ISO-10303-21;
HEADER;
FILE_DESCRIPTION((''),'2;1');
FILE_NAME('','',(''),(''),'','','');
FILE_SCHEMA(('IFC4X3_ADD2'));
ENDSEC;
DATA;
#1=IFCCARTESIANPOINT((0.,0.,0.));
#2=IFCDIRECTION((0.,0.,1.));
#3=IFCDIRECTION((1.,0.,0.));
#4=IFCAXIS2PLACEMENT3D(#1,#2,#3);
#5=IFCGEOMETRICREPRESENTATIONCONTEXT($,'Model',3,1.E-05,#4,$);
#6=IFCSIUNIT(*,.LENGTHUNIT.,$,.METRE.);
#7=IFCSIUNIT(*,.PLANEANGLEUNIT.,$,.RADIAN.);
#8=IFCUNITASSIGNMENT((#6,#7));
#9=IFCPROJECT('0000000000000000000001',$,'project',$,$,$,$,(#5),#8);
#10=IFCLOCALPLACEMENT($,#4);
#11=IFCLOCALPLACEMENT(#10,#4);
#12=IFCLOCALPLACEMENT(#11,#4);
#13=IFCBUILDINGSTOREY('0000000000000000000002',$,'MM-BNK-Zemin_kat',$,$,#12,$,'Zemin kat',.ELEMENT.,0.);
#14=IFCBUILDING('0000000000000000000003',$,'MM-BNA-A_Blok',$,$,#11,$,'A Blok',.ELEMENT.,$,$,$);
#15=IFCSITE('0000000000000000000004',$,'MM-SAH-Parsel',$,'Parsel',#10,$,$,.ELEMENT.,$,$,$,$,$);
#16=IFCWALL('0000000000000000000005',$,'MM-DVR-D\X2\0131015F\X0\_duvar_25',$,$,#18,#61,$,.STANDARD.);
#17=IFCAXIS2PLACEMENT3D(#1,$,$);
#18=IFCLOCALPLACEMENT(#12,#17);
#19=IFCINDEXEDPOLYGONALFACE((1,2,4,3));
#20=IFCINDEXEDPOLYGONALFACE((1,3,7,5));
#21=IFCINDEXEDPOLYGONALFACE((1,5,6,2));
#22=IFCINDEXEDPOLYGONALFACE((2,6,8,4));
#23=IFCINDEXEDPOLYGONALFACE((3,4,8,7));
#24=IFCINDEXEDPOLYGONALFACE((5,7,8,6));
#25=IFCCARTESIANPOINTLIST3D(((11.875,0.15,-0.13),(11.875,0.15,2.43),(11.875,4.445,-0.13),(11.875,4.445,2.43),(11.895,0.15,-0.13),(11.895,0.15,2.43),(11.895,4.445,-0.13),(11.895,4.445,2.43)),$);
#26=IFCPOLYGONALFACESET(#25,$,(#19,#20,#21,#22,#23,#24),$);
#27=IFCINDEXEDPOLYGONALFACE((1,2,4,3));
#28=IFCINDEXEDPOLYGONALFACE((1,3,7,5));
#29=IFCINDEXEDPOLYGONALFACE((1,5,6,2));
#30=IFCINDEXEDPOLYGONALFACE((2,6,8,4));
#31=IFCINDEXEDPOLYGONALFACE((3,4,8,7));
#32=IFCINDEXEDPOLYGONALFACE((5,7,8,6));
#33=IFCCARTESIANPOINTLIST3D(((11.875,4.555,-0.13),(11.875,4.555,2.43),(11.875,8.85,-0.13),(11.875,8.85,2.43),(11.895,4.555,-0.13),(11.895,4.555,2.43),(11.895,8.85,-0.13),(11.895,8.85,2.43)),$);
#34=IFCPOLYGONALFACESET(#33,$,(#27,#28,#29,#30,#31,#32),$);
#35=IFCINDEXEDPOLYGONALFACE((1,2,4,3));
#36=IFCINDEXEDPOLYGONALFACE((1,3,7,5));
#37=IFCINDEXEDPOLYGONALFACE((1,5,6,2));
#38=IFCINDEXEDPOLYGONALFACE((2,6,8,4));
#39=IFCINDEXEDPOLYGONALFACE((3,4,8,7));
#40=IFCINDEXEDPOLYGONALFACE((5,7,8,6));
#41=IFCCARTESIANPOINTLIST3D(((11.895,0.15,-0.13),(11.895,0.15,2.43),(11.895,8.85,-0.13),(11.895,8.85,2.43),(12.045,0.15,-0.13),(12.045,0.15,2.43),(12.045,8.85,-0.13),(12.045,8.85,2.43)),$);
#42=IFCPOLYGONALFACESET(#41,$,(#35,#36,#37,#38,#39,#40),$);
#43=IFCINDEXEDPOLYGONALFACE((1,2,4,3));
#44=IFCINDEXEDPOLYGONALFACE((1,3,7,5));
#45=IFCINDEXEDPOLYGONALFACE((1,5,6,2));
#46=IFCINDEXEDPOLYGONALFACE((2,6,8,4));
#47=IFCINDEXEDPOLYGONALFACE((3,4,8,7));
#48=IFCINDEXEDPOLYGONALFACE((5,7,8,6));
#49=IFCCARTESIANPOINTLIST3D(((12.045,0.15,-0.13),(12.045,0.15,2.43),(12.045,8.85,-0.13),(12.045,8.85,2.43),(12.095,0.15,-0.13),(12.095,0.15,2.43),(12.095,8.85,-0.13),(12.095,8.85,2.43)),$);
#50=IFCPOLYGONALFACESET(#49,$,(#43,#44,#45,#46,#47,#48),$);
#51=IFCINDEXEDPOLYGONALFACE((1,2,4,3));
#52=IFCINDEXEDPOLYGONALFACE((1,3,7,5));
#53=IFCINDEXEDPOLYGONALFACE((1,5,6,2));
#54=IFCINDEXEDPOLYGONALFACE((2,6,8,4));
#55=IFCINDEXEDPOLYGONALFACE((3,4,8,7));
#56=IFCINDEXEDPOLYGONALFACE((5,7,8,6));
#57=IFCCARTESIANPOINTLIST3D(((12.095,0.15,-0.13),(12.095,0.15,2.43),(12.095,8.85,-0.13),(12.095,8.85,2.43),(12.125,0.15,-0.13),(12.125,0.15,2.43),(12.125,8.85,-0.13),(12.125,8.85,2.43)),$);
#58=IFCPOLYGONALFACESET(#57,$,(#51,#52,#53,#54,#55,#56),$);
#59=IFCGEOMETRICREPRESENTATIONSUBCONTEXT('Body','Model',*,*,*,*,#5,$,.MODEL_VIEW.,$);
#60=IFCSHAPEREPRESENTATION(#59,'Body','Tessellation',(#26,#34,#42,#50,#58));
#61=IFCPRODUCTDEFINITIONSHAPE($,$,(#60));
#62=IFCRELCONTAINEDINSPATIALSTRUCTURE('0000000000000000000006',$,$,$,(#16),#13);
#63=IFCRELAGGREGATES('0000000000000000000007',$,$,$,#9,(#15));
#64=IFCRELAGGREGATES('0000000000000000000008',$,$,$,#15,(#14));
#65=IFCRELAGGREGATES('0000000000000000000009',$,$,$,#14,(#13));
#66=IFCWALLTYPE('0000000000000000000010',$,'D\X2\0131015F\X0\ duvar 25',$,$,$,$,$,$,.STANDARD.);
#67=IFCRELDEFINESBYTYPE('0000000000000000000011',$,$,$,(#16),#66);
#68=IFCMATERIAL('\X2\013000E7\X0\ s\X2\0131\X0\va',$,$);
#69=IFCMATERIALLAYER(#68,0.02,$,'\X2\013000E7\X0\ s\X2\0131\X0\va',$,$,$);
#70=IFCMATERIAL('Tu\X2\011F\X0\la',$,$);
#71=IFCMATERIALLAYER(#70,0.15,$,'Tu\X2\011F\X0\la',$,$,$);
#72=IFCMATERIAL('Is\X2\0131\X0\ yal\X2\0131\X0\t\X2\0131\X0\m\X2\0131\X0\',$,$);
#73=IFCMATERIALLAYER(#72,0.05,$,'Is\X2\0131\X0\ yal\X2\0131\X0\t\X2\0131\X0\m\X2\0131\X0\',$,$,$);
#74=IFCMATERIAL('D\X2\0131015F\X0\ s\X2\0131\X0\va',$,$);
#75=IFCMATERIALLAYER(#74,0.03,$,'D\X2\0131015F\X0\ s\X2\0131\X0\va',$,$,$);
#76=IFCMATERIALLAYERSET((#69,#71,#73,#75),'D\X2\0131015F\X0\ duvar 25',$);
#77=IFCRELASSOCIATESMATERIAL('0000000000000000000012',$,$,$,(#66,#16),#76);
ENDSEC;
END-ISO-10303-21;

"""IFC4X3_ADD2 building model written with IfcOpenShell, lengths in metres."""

from ifc_helpers import new_model, si_unit, frame, origin_with_axes, place, context, subcontext, project, spatial, polyline, outline, extrude, material, layer, layer_set, type_object, element, save


model = new_model("IFC4X3_ADD2")

# Units and contexts
model_context = context("Model", 3, precision=1e-05, world=origin_with_axes())
body_context = subcontext(model_context, "Body", "Model", "MODEL_VIEW")
ifc_project = project(units=[si_unit("LENGTHUNIT", "METRE"), si_unit("PLANEANGLEUNIT", "RADIAN")], contexts=[model_context])

# Site, building, storey
site_placement = place(None, origin_with_axes())
site = spatial("IfcSite", under=ifc_project, at=site_placement, Name="MM-SAH-Parsel", ObjectType="Parsel", CompositionType="ELEMENT")
building_placement = place(site_placement, origin_with_axes())
building = spatial("IfcBuilding", under=site, at=building_placement, Name="MM-BNA-A_Blok", LongName="A Blok", CompositionType="ELEMENT")
storey_placement = place(building_placement, origin_with_axes())
storey = spatial("IfcBuildingStorey", under=building, at=storey_placement, Name="MM-BNK-Zemin_kat", LongName="Zemin kat", CompositionType="ELEMENT", Elevation=0.0)

# Shared definitions
ifc_material_1 = material(Name="İç sıva")
ifc_layer_1 = layer(ifc_material_1, 0.02, Name="İç sıva")
ifc_material_2 = material(Name="Tuğla")
ifc_layer_2 = layer(ifc_material_2, 0.15, Name="Tuğla")
ifc_material_3 = material(Name="Isı yalıtımı")
ifc_layer_3 = layer(ifc_material_3, 0.05, Name="Isı yalıtımı")
ifc_material_4 = material(Name="Dış sıva")
ifc_layer_4 = layer(ifc_material_4, 0.03, Name="Dış sıva")
ifc_layer_set_1 = layer_set([ifc_layer_1, ifc_layer_2, ifc_layer_3, ifc_layer_4], Name="Dış duvar 25")
wall_type_1 = type_object("IfcWallType", Name="Dış duvar 25", PredefinedType="STANDARD", material=ifc_layer_set_1)

# Wall
wall_1_placement = place(storey_placement, origin_with_axes())
element("IfcWall", 1, at=wall_1_placement, inside=storey, type_object=wall_type_1, material=ifc_layer_set_1, Name="MM-DVR-Dış_duvar_25", PredefinedType="STANDARD", context=body_context, shape_type="SweptSolid", body=[
    extrude(outline(polyline([(11.895, 0.15), (11.895, 4.445), (11.875, 4.445), (11.875, 0.15), (11.895, 0.15)])), frame((0.0, 0.0, -0.13)), (0.0, 0.0, 1.0), 2.56),
    extrude(outline(polyline([(11.895, 4.555), (11.895, 8.85), (11.875, 8.85), (11.875, 4.555), (11.895, 4.555)])), frame((0.0, 0.0, -0.13)), (0.0, 0.0, 1.0), 2.56),
    extrude(outline(polyline([(12.045, 0.15), (12.045, 8.85), (11.895, 8.85), (11.895, 0.15), (12.045, 0.15)])), frame((0.0, 0.0, -0.13)), (0.0, 0.0, 1.0), 2.56),
    extrude(outline(polyline([(12.095, 0.15), (12.095, 8.85), (12.045, 8.85), (12.045, 0.15), (12.095, 0.15)])), frame((0.0, 0.0, -0.13)), (0.0, 0.0, 1.0), 2.56),
    extrude(outline(polyline([(12.125, 0.15), (12.125, 8.85), (12.095, 8.85), (12.095, 0.15), (12.125, 0.15)])), frame((0.0, 0.0, -0.13)), (0.0, 0.0, 1.0), 2.56),
])

save(model, "model.ifc")
